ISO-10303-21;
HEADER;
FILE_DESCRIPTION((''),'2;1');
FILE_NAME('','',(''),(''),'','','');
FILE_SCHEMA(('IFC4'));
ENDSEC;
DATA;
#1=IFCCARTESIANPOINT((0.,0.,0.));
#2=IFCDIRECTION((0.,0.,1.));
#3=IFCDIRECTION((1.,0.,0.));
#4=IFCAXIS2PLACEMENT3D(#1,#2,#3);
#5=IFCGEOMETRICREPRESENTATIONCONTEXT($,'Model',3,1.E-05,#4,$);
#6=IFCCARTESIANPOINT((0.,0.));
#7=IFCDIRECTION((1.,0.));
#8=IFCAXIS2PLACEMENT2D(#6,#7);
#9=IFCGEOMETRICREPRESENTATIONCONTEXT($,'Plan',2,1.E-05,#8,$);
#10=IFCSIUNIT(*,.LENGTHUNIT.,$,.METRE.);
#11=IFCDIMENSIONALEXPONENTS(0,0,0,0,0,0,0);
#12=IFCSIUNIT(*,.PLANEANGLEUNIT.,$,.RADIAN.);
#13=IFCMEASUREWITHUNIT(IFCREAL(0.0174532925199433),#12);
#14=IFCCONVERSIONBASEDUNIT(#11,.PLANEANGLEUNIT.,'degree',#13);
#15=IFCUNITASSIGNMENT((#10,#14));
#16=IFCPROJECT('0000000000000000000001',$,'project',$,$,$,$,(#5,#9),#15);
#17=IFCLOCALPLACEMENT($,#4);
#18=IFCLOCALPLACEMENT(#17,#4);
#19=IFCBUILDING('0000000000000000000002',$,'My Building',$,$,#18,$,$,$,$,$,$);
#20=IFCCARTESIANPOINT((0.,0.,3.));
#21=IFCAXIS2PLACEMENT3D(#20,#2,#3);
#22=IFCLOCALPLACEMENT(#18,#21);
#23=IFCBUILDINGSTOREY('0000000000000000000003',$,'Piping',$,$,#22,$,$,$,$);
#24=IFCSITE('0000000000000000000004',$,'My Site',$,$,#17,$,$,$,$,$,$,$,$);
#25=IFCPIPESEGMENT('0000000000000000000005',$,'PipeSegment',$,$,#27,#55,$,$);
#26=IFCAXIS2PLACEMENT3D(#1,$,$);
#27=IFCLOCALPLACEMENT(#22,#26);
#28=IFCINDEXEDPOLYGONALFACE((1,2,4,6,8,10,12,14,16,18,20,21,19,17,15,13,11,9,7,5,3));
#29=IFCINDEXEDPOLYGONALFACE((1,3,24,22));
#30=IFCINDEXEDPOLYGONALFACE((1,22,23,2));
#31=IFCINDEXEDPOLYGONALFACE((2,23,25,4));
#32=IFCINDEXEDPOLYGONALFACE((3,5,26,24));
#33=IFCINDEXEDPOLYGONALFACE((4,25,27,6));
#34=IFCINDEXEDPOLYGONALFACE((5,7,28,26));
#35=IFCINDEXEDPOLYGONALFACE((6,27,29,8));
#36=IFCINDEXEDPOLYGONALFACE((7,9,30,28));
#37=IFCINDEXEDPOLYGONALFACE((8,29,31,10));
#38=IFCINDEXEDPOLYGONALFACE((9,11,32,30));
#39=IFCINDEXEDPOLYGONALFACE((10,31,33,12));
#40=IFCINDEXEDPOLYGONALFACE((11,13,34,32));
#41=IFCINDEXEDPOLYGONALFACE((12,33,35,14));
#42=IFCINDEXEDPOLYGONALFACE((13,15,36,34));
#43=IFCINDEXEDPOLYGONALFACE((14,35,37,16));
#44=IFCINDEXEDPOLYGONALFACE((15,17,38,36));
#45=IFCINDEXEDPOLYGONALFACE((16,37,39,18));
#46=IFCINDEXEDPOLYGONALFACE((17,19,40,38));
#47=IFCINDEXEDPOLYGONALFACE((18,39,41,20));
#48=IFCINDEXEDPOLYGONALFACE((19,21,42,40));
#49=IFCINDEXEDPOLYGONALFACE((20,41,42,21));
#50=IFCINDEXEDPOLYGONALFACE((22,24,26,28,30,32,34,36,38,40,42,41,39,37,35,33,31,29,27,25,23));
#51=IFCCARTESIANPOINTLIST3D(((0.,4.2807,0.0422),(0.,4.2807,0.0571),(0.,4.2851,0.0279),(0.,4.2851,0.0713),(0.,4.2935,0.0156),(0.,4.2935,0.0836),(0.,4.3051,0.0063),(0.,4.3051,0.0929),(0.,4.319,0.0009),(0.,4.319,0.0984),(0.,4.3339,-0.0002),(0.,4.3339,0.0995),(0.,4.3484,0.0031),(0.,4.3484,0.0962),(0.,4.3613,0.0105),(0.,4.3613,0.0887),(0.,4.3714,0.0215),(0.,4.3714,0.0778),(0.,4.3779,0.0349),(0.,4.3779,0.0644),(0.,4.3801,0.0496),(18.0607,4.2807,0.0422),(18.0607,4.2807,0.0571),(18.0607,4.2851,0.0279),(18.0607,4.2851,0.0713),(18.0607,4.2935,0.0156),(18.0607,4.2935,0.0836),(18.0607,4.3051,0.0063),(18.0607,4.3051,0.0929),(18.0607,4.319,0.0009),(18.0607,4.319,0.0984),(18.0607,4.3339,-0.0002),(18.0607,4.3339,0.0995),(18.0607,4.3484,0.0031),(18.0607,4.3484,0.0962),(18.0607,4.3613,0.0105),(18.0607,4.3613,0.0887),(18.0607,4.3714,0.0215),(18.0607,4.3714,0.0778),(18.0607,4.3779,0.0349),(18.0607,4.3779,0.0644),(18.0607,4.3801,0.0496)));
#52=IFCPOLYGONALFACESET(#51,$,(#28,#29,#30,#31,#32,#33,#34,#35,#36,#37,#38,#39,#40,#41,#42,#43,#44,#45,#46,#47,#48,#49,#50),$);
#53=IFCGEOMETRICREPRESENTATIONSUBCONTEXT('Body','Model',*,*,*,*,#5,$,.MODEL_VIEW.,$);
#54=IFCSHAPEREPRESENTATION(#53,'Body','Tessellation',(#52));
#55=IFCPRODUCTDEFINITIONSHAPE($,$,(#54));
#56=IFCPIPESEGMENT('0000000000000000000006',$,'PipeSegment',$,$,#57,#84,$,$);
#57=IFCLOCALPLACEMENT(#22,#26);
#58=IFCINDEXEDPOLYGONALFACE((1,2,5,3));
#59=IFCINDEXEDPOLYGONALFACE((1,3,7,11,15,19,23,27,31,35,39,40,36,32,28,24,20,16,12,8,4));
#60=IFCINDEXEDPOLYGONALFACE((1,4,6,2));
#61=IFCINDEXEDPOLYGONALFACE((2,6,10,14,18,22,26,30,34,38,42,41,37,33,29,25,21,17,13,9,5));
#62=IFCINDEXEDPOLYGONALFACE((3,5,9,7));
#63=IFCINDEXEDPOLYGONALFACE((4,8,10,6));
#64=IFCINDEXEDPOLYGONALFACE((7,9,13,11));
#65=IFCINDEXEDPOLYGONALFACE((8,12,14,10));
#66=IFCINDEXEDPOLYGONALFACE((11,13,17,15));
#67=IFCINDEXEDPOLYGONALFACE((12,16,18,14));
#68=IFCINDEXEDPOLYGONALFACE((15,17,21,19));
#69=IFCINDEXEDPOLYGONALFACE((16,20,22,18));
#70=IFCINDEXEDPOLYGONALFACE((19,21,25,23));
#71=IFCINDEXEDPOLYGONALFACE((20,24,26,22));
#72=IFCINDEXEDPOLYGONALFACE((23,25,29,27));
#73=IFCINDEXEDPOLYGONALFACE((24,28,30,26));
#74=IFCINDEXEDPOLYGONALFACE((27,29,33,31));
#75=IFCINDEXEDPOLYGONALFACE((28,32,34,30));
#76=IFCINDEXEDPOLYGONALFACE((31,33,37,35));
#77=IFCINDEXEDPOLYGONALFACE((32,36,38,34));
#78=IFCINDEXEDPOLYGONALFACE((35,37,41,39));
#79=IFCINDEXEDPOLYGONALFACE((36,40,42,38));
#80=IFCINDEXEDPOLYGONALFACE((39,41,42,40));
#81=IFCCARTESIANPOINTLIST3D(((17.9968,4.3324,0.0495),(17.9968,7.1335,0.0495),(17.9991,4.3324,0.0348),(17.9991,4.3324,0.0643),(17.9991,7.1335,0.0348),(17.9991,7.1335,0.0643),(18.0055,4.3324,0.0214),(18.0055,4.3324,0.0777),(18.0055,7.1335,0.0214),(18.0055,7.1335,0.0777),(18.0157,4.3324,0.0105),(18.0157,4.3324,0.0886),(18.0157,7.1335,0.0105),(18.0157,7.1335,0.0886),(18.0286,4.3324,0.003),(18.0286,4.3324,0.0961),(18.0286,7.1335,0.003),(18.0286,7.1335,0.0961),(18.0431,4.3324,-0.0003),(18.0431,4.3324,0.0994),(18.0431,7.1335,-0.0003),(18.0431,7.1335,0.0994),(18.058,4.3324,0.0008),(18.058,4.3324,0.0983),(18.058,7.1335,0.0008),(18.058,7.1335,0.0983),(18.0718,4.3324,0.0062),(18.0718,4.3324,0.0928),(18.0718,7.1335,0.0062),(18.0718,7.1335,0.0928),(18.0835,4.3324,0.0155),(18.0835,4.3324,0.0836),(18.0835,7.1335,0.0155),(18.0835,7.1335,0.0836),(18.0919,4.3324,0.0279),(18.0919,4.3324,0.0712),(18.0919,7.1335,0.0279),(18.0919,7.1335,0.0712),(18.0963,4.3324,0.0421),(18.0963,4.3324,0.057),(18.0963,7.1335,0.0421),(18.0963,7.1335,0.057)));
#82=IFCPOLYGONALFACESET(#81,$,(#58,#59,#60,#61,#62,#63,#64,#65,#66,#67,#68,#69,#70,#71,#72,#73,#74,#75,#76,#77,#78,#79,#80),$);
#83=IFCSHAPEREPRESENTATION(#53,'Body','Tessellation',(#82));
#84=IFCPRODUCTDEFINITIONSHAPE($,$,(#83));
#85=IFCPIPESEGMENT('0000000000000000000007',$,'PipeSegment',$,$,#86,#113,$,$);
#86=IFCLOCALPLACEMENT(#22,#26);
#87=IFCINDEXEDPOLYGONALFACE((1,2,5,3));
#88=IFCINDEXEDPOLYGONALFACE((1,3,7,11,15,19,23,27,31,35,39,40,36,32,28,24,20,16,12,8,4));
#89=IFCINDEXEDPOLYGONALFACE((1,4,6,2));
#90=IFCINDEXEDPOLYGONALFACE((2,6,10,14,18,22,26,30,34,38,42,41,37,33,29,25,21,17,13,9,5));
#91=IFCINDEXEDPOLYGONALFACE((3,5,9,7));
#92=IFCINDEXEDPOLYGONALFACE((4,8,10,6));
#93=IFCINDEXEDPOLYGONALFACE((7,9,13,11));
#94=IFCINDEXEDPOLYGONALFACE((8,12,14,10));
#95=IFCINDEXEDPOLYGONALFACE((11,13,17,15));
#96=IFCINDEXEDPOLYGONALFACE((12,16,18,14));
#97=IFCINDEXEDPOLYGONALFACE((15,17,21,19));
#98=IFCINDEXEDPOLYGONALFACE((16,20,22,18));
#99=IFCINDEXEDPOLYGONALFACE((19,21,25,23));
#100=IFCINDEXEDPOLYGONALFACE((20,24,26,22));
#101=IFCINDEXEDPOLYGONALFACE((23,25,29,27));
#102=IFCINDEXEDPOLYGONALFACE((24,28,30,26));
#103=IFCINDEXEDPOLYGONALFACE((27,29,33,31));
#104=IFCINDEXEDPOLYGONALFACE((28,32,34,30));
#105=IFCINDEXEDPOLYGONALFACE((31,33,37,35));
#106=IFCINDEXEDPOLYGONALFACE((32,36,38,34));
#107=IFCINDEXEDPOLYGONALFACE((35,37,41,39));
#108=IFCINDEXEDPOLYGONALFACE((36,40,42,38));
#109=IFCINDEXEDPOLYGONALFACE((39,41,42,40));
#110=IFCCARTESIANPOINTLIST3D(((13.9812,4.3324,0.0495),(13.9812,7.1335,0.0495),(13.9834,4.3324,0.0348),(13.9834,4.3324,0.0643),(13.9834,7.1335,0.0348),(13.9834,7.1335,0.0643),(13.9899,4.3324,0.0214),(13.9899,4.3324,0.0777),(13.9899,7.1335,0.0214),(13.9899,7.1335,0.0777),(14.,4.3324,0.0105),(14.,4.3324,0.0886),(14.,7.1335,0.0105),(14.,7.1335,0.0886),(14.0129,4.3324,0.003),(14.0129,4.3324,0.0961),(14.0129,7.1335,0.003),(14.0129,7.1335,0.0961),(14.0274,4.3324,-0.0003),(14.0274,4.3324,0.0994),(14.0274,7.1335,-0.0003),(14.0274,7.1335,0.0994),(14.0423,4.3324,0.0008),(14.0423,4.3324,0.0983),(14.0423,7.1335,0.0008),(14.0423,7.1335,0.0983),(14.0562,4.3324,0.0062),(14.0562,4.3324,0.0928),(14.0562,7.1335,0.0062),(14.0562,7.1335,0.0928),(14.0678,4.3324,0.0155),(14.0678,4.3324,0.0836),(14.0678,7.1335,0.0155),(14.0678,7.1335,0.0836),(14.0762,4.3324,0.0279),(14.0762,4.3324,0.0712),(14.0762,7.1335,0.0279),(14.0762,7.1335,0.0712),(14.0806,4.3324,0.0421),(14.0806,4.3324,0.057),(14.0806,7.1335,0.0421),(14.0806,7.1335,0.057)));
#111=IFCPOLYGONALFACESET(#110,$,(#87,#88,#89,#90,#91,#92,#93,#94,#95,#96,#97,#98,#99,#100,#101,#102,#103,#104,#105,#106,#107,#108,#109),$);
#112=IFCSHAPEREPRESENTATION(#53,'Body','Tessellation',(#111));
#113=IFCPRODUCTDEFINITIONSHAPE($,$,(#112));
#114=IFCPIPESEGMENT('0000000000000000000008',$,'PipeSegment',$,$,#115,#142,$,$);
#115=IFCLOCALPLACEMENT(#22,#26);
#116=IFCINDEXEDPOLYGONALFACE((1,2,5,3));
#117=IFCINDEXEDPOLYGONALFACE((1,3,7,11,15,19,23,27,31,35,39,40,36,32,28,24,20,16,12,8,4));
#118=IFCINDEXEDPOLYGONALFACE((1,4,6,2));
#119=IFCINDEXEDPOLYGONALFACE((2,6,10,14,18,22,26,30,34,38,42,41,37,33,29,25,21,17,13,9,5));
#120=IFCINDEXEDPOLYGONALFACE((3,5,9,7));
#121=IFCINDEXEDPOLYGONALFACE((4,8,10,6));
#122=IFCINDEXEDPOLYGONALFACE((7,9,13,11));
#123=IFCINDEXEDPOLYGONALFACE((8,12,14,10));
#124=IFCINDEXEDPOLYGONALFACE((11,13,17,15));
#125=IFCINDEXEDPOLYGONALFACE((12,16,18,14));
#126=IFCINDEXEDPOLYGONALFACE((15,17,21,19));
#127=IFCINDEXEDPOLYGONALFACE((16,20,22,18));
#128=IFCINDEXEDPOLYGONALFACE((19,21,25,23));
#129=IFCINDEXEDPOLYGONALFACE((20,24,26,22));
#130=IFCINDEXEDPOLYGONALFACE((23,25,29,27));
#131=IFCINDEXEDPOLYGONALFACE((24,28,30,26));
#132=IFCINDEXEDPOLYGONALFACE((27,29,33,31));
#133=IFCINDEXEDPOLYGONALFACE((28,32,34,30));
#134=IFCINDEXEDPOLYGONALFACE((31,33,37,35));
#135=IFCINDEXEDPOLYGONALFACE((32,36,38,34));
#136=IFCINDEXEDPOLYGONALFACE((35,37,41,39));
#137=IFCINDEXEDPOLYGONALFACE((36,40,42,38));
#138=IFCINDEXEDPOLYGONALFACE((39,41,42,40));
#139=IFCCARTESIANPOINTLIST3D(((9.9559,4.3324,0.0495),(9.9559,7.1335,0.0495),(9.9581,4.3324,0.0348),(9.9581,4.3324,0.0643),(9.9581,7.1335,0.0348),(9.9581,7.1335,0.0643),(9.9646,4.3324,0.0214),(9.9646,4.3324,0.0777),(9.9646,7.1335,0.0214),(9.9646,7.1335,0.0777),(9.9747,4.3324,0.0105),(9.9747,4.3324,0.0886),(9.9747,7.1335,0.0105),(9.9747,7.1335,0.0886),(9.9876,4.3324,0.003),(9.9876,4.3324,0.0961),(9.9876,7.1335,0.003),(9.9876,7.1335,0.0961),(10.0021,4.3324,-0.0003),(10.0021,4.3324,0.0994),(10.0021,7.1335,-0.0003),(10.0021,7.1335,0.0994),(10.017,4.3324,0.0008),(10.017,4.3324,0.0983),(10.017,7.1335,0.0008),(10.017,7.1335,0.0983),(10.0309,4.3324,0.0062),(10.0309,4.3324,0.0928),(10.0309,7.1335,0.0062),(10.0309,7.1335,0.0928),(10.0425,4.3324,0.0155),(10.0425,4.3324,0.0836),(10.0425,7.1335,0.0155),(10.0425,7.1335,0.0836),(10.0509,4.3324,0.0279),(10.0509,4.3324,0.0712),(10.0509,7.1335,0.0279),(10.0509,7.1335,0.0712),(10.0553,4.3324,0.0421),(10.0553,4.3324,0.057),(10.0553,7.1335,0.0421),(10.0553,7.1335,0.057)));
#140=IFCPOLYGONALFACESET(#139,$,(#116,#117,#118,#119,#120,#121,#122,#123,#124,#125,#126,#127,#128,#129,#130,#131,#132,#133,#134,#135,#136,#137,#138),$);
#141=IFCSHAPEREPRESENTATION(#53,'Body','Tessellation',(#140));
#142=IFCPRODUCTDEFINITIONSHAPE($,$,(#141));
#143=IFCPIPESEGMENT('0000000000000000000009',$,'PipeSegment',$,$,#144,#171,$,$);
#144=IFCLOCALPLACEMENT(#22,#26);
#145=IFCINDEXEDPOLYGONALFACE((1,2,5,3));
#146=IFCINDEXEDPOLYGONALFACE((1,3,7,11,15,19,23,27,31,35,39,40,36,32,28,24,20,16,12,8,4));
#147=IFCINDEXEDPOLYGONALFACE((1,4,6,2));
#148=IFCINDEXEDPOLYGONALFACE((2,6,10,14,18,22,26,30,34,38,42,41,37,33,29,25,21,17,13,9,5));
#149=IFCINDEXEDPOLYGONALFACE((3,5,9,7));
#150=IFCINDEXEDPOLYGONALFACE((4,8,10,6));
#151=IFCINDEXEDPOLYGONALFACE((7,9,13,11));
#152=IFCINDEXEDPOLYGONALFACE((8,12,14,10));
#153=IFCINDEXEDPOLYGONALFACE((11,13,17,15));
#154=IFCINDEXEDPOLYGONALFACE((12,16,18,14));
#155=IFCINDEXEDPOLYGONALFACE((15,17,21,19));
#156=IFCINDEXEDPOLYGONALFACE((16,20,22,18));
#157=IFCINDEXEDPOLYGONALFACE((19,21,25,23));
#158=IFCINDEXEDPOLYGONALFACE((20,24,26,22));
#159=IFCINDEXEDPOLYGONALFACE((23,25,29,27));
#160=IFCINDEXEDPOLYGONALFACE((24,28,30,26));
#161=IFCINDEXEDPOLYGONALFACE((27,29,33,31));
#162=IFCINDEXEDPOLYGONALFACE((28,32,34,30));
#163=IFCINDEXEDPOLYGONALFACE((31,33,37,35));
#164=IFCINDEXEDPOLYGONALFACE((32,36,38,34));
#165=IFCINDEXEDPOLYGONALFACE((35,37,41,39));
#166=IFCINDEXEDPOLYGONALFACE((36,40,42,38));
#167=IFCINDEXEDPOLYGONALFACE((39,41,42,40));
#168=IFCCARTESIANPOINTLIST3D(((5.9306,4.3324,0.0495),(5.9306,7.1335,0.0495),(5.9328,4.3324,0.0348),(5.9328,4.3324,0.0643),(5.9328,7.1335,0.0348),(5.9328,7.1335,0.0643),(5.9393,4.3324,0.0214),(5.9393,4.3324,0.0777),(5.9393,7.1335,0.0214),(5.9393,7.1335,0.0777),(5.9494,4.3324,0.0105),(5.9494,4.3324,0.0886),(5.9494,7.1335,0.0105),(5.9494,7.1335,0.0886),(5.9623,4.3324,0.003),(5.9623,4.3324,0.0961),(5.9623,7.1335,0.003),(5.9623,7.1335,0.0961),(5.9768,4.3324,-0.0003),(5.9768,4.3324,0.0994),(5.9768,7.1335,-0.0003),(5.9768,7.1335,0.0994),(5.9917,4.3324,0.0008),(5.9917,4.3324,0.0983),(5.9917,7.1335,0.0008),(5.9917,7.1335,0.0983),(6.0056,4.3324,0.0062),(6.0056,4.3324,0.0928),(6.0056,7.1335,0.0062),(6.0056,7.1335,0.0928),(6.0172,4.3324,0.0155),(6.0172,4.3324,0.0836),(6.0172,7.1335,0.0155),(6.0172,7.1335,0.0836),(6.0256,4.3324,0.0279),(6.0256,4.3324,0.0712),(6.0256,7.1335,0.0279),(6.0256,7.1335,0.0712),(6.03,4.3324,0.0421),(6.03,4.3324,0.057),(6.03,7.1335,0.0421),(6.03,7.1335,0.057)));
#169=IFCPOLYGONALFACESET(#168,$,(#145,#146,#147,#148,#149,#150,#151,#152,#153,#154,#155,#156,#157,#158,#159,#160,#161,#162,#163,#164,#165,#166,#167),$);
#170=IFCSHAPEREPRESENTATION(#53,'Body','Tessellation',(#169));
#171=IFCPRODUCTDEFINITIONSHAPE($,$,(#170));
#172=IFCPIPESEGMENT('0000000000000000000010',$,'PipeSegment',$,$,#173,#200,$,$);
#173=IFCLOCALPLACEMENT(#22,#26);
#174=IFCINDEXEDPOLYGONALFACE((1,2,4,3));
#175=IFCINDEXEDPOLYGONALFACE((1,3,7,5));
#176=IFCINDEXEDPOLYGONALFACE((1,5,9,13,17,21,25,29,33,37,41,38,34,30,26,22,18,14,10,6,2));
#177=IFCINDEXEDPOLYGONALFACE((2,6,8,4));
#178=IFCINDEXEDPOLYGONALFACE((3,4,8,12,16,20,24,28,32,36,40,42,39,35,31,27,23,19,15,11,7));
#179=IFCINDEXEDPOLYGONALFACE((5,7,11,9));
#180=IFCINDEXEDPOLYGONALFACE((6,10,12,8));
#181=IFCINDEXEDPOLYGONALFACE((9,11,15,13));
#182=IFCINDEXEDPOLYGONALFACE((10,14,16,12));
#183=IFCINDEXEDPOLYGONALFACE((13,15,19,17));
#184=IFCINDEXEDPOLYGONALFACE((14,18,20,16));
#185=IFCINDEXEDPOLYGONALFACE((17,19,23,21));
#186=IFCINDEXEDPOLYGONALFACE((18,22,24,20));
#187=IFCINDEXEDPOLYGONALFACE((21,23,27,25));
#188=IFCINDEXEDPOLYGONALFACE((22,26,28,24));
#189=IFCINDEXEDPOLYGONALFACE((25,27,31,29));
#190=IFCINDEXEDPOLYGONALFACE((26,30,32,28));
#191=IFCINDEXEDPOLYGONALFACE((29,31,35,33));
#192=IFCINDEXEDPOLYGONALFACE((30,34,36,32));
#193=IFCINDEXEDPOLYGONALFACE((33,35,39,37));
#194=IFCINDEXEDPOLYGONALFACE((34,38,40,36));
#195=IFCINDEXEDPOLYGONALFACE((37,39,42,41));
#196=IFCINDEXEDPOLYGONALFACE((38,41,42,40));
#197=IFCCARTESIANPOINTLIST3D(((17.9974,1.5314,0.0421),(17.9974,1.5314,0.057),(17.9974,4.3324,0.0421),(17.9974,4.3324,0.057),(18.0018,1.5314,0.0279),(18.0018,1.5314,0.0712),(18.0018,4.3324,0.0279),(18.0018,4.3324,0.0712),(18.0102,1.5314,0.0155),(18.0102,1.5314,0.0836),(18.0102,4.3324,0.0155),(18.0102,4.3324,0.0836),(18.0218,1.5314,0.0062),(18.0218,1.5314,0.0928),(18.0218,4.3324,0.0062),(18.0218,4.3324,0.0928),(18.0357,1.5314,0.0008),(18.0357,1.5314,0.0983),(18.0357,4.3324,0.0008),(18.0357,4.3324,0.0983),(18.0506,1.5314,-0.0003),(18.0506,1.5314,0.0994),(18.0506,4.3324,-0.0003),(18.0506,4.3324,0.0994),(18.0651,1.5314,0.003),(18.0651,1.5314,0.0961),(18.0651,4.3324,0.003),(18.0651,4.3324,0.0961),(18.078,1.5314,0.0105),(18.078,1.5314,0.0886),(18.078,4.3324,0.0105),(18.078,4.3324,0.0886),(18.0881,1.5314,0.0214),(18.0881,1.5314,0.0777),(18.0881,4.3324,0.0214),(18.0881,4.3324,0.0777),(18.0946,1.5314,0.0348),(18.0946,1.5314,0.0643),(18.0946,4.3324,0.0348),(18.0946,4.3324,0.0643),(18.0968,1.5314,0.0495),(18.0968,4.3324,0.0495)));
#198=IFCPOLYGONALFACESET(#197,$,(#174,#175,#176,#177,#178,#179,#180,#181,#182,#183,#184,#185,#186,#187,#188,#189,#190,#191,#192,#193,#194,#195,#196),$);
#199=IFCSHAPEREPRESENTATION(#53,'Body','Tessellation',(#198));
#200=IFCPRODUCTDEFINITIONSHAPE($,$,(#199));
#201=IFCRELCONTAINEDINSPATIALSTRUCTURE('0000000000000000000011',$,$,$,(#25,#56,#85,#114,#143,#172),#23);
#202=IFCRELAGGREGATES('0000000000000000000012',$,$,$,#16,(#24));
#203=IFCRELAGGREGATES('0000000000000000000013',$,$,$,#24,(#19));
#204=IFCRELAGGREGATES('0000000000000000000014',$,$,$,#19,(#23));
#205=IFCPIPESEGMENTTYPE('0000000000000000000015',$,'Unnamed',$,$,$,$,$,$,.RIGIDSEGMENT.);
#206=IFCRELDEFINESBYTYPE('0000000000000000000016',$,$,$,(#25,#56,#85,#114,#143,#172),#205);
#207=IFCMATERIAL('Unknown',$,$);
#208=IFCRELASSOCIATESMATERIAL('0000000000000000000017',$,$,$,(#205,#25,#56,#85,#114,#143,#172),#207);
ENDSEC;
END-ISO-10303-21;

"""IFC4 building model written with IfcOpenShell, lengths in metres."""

from ifc_helpers import new_model, entity, si_unit, converted_unit, frame, origin_with_axes, origin_2d_with_axis, place, context, subcontext, project, spatial, circle, extrude, material, material_profile, profile_set, profile_usage, type_object, element, save


model = new_model("IFC4")

# Units and contexts
model_context = context("Model", 3, precision=1e-05, world=origin_with_axes())
plan_context = context("Plan", 2, precision=1e-05, world=origin_2d_with_axis())
body_context = subcontext(model_context, "Body", "Model", "MODEL_VIEW")
ifc_project = project(units=[si_unit("LENGTHUNIT", "METRE"), converted_unit("PLANEANGLEUNIT", "degree", entity("IfcReal", 0.0174532925199433), si_unit("PLANEANGLEUNIT", "RADIAN"), dimensions=[0, 0, 0, 0, 0, 0, 0])], contexts=[model_context, plan_context])

# Site, building, storey
site_placement = place(None, origin_with_axes())
site = spatial("IfcSite", under=ifc_project, at=site_placement, Name="My Site")
building_placement = place(site_placement, origin_with_axes())
building = spatial("IfcBuilding", under=site, at=building_placement, Name="My Building")
storey_placement = place(building_placement, frame((0.0, 0.0, 3.0), z_axis=(0.0, 0.0, 1.0), x_axis=(1.0, 0.0, 0.0)))
storey = spatial("IfcBuildingStorey", under=building, at=storey_placement, Name="Piping")

# Pipe segments
ifc_material = material(Name="Unknown")
ifc_material_profile = material_profile(ifc_material, circle(Radius=0.05))
ifc_profile_set = profile_set([ifc_material_profile])
ifc_profile_usage_1 = profile_usage(ifc_profile_set, cardinal=5)
pipe_segment_type = type_object("IfcPipeSegmentType", Name="Unnamed", PredefinedType="RIGIDSEGMENT", material=ifc_profile_set)
pipe_segment_1_placement = place(storey_placement, frame((0.0, 4.3301, 0.0496), z_axis=(1.0, 0.0, 0.0), x_axis=(0.0, 1.0, 0.0)))
element("IfcPipeSegment", 1, at=pipe_segment_1_placement, inside=storey, type_object=pipe_segment_type, material=ifc_profile_usage_1, Name="PipeSegment", context=body_context, shape_type="SweptSolid", body=[
    extrude(circle(Radius=0.05), origin_with_axes(), (0.0, 0.0, 1.0), 18.0607),
])
ifc_profile_usage_2 = profile_usage(ifc_profile_set, cardinal=5)
pipe_segment_2_placement = place(storey_placement, frame((18.0468, 4.3324, 0.0495), z_axis=(0.0, 1.0, 0.0), x_axis=(-1.0, 0.0, 0.0)))
element("IfcPipeSegment", 2, at=pipe_segment_2_placement, inside=storey, type_object=pipe_segment_type, material=ifc_profile_usage_2, Name="PipeSegment", context=body_context, shape_type="SweptSolid", body=[
    extrude(circle(Radius=0.05), origin_with_axes(), (0.0, 0.0, 1.0), 2.8011),
])
ifc_profile_usage_3 = profile_usage(ifc_profile_set, cardinal=5)
pipe_segment_3_placement = place(storey_placement, frame((14.0312, 4.3324, 0.0495), z_axis=(0.0, 1.0, 0.0), x_axis=(-1.0, 0.0, 0.0)))
element("IfcPipeSegment", 3, at=pipe_segment_3_placement, inside=storey, type_object=pipe_segment_type, material=ifc_profile_usage_3, Name="PipeSegment", context=body_context, shape_type="SweptSolid", body=[
    extrude(circle(Radius=0.05), origin_with_axes(), (0.0, 0.0, 1.0), 2.8011),
])
ifc_profile_usage_4 = profile_usage(ifc_profile_set, cardinal=5)
pipe_segment_4_placement = place(storey_placement, frame((10.0059, 4.3324, 0.0495), z_axis=(0.0, 1.0, 0.0), x_axis=(-1.0, 0.0, 0.0)))
element("IfcPipeSegment", 4, at=pipe_segment_4_placement, inside=storey, type_object=pipe_segment_type, material=ifc_profile_usage_4, Name="PipeSegment", context=body_context, shape_type="SweptSolid", body=[
    extrude(circle(Radius=0.05), origin_with_axes(), (0.0, 0.0, 1.0), 2.8011),
])
ifc_profile_usage_5 = profile_usage(ifc_profile_set, cardinal=5)
pipe_segment_5_placement = place(storey_placement, frame((5.9806, 4.3324, 0.0495), z_axis=(0.0, 1.0, 0.0), x_axis=(-1.0, 0.0, 0.0)))
element("IfcPipeSegment", 5, at=pipe_segment_5_placement, inside=storey, type_object=pipe_segment_type, material=ifc_profile_usage_5, Name="PipeSegment", context=body_context, shape_type="SweptSolid", body=[
    extrude(circle(Radius=0.05), origin_with_axes(), (0.0, 0.0, 1.0), 2.8011),
])
ifc_profile_usage_6 = profile_usage(ifc_profile_set, cardinal=5)
pipe_segment_6_placement = place(storey_placement, frame((18.0468, 4.3324, 0.0495), z_axis=(0.0, -1.0, 0.0), x_axis=(1.0, 0.0, 0.0)))
element("IfcPipeSegment", 6, at=pipe_segment_6_placement, inside=storey, type_object=pipe_segment_type, material=ifc_profile_usage_6, Name="PipeSegment", context=body_context, shape_type="SweptSolid", body=[
    extrude(circle(Radius=0.05), origin_with_axes(), (0.0, 0.0, 1.0), 2.8011),
])

save(model, "model.ifc")
